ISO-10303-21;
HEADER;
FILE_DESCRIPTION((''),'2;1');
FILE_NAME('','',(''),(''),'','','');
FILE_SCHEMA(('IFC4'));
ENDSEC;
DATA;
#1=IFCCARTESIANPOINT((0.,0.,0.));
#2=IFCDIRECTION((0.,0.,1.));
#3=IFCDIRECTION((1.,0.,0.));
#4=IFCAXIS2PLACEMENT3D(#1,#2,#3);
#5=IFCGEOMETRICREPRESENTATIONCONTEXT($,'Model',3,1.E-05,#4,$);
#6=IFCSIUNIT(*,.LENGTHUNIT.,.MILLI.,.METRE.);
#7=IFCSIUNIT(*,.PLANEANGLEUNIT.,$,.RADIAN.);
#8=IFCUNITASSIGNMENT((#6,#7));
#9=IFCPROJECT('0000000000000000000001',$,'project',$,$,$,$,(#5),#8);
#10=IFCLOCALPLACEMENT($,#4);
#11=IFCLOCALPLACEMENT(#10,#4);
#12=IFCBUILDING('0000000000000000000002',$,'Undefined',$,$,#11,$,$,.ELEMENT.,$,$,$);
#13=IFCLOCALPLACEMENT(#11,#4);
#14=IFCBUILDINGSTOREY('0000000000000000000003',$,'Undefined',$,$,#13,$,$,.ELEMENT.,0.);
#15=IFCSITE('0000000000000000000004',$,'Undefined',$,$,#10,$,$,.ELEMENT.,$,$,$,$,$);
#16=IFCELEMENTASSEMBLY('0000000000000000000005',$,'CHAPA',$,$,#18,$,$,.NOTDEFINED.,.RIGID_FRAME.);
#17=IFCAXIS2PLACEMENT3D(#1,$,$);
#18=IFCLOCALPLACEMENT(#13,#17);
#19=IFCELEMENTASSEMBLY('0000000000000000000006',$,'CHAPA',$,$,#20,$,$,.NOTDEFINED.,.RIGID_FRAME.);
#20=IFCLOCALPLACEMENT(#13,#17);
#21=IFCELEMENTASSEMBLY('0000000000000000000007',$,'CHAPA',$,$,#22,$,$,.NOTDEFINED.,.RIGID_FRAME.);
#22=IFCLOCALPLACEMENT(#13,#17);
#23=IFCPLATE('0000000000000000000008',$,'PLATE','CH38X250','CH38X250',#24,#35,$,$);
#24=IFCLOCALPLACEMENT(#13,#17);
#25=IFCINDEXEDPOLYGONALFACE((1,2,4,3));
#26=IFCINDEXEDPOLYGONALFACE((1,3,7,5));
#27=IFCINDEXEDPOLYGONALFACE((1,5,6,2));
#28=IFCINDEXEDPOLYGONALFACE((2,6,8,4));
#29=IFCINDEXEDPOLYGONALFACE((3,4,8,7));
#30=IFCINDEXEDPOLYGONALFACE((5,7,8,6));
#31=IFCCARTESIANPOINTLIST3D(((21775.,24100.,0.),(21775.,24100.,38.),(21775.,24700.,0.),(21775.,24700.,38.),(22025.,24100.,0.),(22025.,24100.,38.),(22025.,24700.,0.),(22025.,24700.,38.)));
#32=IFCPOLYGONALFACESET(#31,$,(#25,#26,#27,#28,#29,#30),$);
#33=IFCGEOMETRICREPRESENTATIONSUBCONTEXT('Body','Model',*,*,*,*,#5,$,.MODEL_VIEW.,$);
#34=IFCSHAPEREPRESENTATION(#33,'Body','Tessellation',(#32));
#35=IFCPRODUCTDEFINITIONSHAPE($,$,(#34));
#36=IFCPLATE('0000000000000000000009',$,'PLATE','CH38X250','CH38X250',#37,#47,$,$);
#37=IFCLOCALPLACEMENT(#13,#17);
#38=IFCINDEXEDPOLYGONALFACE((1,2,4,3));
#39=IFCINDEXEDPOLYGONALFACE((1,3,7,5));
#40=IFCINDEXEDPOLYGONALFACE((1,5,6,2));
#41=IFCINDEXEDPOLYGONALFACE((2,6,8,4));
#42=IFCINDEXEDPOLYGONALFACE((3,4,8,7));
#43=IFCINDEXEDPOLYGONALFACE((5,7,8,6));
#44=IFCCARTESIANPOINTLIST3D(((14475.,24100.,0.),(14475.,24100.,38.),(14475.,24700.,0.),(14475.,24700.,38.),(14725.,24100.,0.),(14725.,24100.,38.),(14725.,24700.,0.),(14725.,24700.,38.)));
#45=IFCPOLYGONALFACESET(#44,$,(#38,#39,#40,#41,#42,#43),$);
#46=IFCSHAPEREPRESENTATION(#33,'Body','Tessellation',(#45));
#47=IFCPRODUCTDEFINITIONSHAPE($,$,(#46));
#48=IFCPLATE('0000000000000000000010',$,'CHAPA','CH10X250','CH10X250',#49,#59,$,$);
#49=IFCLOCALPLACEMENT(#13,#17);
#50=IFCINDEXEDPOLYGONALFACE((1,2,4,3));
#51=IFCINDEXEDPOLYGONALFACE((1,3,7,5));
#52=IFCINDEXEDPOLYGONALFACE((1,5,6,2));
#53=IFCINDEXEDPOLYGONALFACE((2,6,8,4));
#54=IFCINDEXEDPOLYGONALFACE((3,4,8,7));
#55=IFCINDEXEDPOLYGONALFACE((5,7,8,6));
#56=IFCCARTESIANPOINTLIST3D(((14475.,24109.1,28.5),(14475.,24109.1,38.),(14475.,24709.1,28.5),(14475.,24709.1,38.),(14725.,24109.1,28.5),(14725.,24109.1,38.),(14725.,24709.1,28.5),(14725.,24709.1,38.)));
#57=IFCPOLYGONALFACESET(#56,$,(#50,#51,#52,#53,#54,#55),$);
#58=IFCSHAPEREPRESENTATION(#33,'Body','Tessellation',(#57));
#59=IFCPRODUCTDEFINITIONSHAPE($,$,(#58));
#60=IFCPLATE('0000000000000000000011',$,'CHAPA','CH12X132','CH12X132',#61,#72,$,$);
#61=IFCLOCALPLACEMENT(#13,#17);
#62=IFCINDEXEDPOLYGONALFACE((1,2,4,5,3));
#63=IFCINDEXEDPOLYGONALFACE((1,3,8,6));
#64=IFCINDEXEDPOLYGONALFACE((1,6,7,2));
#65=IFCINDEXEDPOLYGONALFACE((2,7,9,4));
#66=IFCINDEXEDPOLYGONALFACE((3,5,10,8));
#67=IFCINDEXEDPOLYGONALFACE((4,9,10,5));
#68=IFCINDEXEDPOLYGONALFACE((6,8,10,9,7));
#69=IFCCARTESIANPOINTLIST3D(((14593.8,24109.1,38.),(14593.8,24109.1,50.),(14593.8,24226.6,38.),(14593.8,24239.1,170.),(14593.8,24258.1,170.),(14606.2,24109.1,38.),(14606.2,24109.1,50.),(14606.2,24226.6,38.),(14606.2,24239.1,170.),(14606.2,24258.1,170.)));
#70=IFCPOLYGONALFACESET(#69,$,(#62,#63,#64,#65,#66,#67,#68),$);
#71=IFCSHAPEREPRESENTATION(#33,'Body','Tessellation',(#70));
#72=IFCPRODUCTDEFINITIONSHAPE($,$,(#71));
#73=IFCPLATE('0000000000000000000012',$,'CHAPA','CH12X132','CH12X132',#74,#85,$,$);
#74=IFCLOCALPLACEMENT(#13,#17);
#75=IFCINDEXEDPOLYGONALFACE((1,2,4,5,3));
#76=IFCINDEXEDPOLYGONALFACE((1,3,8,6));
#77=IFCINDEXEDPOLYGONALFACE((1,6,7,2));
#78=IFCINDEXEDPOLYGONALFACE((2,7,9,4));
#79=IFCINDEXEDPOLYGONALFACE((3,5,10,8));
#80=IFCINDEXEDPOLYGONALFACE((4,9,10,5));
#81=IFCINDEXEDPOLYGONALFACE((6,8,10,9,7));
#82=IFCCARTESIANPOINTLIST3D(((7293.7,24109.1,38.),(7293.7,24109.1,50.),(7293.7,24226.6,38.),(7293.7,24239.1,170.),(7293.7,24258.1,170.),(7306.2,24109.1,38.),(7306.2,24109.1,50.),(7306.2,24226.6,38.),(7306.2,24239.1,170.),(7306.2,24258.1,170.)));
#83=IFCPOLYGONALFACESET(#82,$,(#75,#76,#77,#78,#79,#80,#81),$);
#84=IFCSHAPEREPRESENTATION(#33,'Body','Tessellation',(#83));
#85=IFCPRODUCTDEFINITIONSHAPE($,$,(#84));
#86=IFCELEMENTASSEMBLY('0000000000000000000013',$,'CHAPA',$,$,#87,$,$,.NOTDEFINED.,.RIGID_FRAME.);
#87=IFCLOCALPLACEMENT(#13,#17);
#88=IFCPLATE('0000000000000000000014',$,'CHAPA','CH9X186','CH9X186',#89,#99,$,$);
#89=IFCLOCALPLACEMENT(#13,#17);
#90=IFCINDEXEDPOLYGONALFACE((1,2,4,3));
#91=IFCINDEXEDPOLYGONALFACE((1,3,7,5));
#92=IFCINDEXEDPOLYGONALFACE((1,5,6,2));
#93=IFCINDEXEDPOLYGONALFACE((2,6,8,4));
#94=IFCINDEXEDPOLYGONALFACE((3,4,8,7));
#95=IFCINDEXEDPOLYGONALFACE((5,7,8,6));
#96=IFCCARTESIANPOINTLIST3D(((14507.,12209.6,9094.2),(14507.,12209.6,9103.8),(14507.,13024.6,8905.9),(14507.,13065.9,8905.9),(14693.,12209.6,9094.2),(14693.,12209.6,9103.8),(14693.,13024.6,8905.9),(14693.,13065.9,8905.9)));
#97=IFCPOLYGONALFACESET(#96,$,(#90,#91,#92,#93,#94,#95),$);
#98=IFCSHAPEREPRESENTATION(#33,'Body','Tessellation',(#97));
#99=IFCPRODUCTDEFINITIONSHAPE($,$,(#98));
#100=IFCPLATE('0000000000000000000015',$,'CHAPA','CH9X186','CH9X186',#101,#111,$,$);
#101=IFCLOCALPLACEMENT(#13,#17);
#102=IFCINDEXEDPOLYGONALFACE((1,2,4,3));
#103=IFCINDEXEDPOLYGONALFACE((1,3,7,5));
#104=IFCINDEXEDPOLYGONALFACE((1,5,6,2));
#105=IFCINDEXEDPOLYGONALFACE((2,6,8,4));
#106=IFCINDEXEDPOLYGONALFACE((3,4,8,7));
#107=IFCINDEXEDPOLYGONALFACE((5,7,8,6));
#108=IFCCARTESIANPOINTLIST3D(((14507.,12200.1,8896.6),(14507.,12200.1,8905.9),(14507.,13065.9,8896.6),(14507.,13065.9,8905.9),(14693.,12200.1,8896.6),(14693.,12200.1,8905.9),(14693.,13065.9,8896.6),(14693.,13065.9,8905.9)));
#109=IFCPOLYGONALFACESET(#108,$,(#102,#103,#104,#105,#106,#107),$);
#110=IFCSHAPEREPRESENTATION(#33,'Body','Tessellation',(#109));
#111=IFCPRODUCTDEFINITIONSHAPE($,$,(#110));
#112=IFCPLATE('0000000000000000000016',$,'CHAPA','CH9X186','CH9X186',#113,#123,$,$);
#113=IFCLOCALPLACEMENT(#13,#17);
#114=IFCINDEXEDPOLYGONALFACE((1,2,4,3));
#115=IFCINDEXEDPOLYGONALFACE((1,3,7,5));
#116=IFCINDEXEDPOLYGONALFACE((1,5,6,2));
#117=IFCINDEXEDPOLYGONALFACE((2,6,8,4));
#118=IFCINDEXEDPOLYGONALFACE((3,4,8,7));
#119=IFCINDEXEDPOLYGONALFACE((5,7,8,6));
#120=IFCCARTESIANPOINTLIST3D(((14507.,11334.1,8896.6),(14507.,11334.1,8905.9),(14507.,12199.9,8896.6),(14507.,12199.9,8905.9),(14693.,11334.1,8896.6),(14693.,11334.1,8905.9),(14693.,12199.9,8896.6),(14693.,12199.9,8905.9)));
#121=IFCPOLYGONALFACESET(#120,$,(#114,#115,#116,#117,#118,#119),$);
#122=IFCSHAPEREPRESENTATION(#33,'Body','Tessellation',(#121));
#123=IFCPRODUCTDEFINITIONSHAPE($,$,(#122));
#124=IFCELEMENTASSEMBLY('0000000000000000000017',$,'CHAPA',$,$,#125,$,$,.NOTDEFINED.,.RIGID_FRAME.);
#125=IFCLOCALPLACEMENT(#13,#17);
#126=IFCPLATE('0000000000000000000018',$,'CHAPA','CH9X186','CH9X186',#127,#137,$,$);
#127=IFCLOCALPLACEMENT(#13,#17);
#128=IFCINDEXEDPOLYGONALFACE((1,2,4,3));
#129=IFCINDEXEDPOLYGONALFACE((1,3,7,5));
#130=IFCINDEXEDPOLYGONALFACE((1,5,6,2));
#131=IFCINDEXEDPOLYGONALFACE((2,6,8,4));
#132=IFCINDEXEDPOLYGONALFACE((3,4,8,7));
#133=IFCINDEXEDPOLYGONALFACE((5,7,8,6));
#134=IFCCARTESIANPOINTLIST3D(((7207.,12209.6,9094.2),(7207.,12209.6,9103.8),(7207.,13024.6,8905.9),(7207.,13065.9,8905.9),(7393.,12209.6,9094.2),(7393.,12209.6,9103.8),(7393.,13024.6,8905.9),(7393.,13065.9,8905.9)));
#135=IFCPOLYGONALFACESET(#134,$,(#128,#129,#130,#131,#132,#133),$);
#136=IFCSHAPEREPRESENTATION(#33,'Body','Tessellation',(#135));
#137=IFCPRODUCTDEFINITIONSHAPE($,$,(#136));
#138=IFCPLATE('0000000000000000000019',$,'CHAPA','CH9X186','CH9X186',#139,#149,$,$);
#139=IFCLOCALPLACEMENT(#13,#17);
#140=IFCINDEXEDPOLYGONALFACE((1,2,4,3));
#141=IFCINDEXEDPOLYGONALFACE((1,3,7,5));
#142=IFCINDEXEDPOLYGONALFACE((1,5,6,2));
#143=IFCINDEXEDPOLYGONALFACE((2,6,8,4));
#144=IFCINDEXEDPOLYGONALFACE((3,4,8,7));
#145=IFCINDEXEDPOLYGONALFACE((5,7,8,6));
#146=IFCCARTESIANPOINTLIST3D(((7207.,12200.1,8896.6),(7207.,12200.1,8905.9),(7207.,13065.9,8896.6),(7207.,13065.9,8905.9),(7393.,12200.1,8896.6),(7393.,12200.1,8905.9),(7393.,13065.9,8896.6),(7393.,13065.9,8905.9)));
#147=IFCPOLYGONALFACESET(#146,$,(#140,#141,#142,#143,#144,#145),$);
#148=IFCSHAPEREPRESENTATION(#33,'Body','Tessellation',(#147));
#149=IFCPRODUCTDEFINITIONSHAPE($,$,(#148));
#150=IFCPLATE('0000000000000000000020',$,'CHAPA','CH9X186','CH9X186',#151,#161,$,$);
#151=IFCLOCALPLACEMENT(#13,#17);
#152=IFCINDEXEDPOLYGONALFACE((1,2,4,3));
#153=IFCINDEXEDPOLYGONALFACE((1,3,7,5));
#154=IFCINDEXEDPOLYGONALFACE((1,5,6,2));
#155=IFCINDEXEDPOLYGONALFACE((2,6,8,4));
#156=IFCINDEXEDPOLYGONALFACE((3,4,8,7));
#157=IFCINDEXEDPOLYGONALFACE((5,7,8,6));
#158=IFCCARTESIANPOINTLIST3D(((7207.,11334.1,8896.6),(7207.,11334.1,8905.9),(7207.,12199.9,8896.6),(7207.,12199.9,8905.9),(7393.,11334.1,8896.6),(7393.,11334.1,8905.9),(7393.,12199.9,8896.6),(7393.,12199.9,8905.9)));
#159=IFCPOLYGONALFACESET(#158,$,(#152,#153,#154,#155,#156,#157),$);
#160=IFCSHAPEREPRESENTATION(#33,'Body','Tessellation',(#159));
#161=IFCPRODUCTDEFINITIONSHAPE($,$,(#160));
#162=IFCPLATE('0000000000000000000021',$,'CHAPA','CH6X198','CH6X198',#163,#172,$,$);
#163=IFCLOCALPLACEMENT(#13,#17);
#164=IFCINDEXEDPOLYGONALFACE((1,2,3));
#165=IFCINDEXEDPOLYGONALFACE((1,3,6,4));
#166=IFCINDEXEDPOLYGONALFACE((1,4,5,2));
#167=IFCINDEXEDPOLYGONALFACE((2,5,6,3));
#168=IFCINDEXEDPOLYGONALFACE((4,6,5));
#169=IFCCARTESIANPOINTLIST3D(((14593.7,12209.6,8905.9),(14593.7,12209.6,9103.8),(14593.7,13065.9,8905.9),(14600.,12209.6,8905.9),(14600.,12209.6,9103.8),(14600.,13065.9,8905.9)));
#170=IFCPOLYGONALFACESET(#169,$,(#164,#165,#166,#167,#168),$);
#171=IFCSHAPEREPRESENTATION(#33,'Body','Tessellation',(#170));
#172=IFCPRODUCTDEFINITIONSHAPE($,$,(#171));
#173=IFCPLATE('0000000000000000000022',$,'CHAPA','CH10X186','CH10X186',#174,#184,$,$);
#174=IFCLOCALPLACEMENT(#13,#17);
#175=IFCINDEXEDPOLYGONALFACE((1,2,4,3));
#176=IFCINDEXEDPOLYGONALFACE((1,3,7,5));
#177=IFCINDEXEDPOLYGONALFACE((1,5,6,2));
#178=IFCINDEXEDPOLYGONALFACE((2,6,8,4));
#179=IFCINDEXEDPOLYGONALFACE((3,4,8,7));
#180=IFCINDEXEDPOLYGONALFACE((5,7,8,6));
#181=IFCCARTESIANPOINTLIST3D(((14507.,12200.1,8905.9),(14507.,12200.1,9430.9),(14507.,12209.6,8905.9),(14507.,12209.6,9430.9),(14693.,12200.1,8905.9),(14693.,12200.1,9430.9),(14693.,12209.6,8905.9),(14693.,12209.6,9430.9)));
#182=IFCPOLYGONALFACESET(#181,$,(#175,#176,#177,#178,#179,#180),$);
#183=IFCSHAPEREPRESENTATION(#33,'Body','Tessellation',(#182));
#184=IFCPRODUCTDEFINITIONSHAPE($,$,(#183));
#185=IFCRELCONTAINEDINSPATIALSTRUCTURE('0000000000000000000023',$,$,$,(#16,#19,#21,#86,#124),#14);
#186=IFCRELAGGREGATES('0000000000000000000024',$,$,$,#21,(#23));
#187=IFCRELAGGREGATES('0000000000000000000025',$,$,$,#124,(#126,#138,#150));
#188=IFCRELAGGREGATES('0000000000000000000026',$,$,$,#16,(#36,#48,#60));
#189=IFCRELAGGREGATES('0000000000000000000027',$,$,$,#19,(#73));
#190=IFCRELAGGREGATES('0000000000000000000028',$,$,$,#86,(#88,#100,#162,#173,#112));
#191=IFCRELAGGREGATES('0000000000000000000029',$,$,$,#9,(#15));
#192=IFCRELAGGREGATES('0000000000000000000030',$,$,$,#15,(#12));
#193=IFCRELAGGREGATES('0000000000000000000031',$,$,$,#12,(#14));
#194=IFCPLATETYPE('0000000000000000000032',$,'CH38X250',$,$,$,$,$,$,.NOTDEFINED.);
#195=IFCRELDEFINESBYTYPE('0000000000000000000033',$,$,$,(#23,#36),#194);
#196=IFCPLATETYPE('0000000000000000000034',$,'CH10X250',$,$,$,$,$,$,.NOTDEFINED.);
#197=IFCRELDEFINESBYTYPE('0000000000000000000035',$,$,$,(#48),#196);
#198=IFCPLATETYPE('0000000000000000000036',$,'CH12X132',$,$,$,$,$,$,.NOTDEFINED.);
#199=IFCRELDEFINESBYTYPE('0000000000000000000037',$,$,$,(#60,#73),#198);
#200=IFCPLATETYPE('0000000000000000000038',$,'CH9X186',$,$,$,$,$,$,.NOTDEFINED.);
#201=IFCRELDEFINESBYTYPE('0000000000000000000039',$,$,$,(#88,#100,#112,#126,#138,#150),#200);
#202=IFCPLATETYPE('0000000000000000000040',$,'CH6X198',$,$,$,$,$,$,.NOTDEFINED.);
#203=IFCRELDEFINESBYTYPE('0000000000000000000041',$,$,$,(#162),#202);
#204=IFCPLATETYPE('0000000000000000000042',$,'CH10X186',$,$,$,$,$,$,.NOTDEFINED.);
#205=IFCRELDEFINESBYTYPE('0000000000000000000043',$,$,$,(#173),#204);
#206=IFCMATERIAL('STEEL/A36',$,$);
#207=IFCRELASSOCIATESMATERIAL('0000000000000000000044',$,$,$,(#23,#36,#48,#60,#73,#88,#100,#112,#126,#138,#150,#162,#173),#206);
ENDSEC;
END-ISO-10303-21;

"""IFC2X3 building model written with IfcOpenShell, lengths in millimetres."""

from ifc_helpers import new_model, si_unit, frame, origin_with_axes, place, context, subcontext, project, spatial, polyline, outline, extrude, clip, halfspace, material, type_object, element, aggregate, save


model = new_model("IFC2X3")

# Units and contexts
model_context = context("Model", 3, precision=1e-05, world=origin_with_axes())
body_context = subcontext(model_context, "Body", "Model", "MODEL_VIEW")
ifc_project = project(units=[si_unit("LENGTHUNIT", "METRE", prefix="MILLI"), si_unit("PLANEANGLEUNIT", "RADIAN")], contexts=[model_context])

# Site, building, storey
site_placement = place(None, origin_with_axes())
site = spatial("IfcSite", under=ifc_project, at=site_placement, Name="Undefined", CompositionType="ELEMENT")
building_placement = place(site_placement, origin_with_axes())
building = spatial("IfcBuilding", under=site, at=building_placement, Name="Undefined", CompositionType="ELEMENT")
storey_placement = place(building_placement, origin_with_axes())
storey = spatial("IfcBuildingStorey", under=building, at=storey_placement, Name="Undefined", CompositionType="ELEMENT", Elevation=0.0)

# Element assemblies
assembly_1_placement = place(storey_placement, origin_with_axes())
assembly_1 = element("IfcElementAssembly", 1, at=assembly_1_placement, inside=storey, Name="CHAPA", AssemblyPlace="NOTDEFINED", PredefinedType="RIGID_FRAME")
assembly_2_placement = place(storey_placement, origin_with_axes())
assembly_2 = element("IfcElementAssembly", 2, at=assembly_2_placement, inside=storey, Name="CHAPA", AssemblyPlace="NOTDEFINED", PredefinedType="RIGID_FRAME")

# Element assembly, plate
assembly_3_placement = place(storey_placement, origin_with_axes())
assembly_3 = element("IfcElementAssembly", 3, at=assembly_3_placement, inside=storey, Name="CHAPA", AssemblyPlace="NOTDEFINED", PredefinedType="RIGID_FRAME")
ifc_material_1 = material(Name="STEEL/A36")
plate_type_1 = type_object("IfcPlateType", Name="CH38X250", PredefinedType="NOTDEFINED")
plate_1_placement = place(assembly_3_placement, frame((21775.0, 24700.0, 19.0), z_axis=(0.0, 0.0, 1.0), x_axis=(0.0, -1.0, 0.0)))
plate_1 = element("IfcPlate", 4, at=plate_1_placement, type_object=plate_type_1, material=ifc_material_1, Name="PLATE", Description="CH38X250", ObjectType="CH38X250", context=body_context, shape_type="SweptSolid", body=[
    extrude(outline(polyline([(0.0, 0.0), (600.0, 0.0), (600.0, 250.0), (0.0, 250.0), (0.0, 0.0)])), frame((0.0, 0.0, -19.0), z_axis=(0.0, 0.0, 1.0), x_axis=(1.0, 0.0, 0.0)), (0.0, 0.0, 1.0), 38.0),
])
aggregate(assembly_3, [plate_1])

# Plates
plate_2_placement = place(assembly_1_placement, frame((14475.0, 24700.0, 19.0), z_axis=(0.0, 0.0, 1.0), x_axis=(0.0, -1.0, 0.0)))
plate_2 = element("IfcPlate", 5, at=plate_2_placement, type_object=plate_type_1, material=ifc_material_1, Name="PLATE", Description="CH38X250", ObjectType="CH38X250", context=body_context, shape_type="SweptSolid", body=[
    extrude(outline(polyline([(0.0, 0.0), (600.0, 0.0), (600.0, 250.0), (0.0, 250.0), (0.0, 0.0)])), frame((0.0, 0.0, -19.0), z_axis=(0.0, 0.0, 1.0), x_axis=(1.0, 0.0, 0.0)), (0.0, 0.0, 1.0), 38.0),
])
plate_type_2 = type_object("IfcPlateType", Name="CH10X250", PredefinedType="NOTDEFINED")
plate_3_placement = place(assembly_1_placement, frame((14475.0, 24709.1, 33.2), z_axis=(0.0, 0.0, -1.0), x_axis=(1.0, 0.0, 0.0)))
plate_3 = element("IfcPlate", 6, at=plate_3_placement, type_object=plate_type_2, material=ifc_material_1, Name="CHAPA", Description="CH10X250", ObjectType="CH10X250", context=body_context, shape_type="SweptSolid", body=[
    extrude(outline(polyline([(0.0, 0.0), (250.0, 0.0), (250.0, 600.0), (0.0, 600.0), (0.0, 0.0)])), frame((0.0, 0.0, -4.8), z_axis=(0.0, 0.0, 1.0), x_axis=(1.0, 0.0, 0.0)), (0.0, 0.0, 1.0), 9.5),
])
plate_type_3 = type_object("IfcPlateType", Name="CH12X132", PredefinedType="NOTDEFINED")
plate_4_placement = place(assembly_1_placement, frame((14600.0, 24226.6, 38.0), z_axis=(-1.0, 0.0, 0.0), x_axis=(0.0, -1.0, 0.0)))
plate_4 = element("IfcPlate", 7, at=plate_4_placement, type_object=plate_type_3, material=ifc_material_1, Name="CHAPA", Description="CH12X132", ObjectType="CH12X132", context=body_context, shape_type="SweptSolid", body=[
    extrude(outline(polyline([(0.0, 0.0), (117.5, 0.0), (117.5, 12.0), (-12.5, 132.0), (-31.6, 132.0), (0.0, 0.0)])), frame((0.0, 0.0, -6.2), z_axis=(0.0, 0.0, 1.0), x_axis=(1.0, 0.0, 0.0)), (0.0, 0.0, 1.0), 12.5),
])
plate_5_placement = place(assembly_2_placement, frame((7300.0, 24226.6, 38.0), z_axis=(-1.0, 0.0, 0.0), x_axis=(0.0, -1.0, 0.0)))
plate_5 = element("IfcPlate", 8, at=plate_5_placement, type_object=plate_type_3, material=ifc_material_1, Name="CHAPA", Description="CH12X132", ObjectType="CH12X132", context=body_context, shape_type="SweptSolid", body=[
    extrude(outline(polyline([(0.0, 0.0), (117.5, 0.0), (117.5, 12.0), (-12.5, 132.0), (-31.6, 132.0), (0.0, 0.0)])), frame((0.0, 0.0, -6.2), z_axis=(0.0, 0.0, 1.0), x_axis=(1.0, 0.0, 0.0)), (0.0, 0.0, 1.0), 12.5),
])

# Element assemblies, plates
assembly_4_placement = place(storey_placement, origin_with_axes())
assembly_4 = element("IfcElementAssembly", 9, at=assembly_4_placement, inside=storey, Name="CHAPA", AssemblyPlace="NOTDEFINED", PredefinedType="RIGID_FRAME")
plate_type_4 = type_object("IfcPlateType", Name="CH9X186", PredefinedType="NOTDEFINED")
plate_6_placement = place(assembly_4_placement, frame((14693.0, 12208.6, 9099.3), z_axis=(0.0, -0.225125, -0.97433), x_axis=(-1.0, 0.0, 0.0)))
plate_6 = element("IfcPlate", 10, at=plate_6_placement, type_object=plate_type_4, material=ifc_material_1, Name="CHAPA", Description="CH9X186", ObjectType="CH9X186", context=body_context, shape_type="Clipping", body=[
    clip(clip(extrude(outline(polyline([(0.0, 0.0), (186.0, 0.0), (186.0, 878.9), (0.0, 878.9), (0.0, 0.0)])), frame((0.0, 0.0, -4.7), z_axis=(0.0, 0.0, 1.0), x_axis=(1.0, 0.0, 0.0)), (0.0, 0.0, 1.0), 9.3), halfspace(frame((186.0, -500.0, 314.0), z_axis=(0.0, 0.225128, 0.974329), x_axis=(-1.0, 0.0, 0.0)), False)), halfspace(frame((0.0, 2.1, 4.7), z_axis=(0.0, -0.97433, 0.225125), x_axis=(1.0, 0.0, 0.0)), False)),
])
plate_7_placement = place(assembly_4_placement, frame((14693.0, 12200.1, 8901.3), z_axis=(0.0, 0.0, -1.0), x_axis=(-1.0, 0.0, 0.0)))
plate_7 = element("IfcPlate", 11, at=plate_7_placement, type_object=plate_type_4, material=ifc_material_1, Name="CHAPA", Description="CH9X186", ObjectType="CH9X186", context=body_context, shape_type="SweptSolid", body=[
    extrude(outline(polyline([(0.0, 0.0), (186.0, 0.0), (186.0, 865.8), (0.0, 865.8), (0.0, 0.0)])), frame((0.0, 0.0, -4.7), z_axis=(0.0, 0.0, 1.0), x_axis=(1.0, 0.0, 0.0)), (0.0, 0.0, 1.0), 9.3),
])
plate_8_placement = place(assembly_4_placement, frame((14693.0, 12199.9, 8901.3), z_axis=(0.0, 0.0, 1.0), x_axis=(-1.0, 0.0, 0.0)))
plate_8 = element("IfcPlate", 12, at=plate_8_placement, type_object=plate_type_4, material=ifc_material_1, Name="CHAPA", Description="CH9X186", ObjectType="CH9X186", context=body_context, shape_type="SweptSolid", body=[
    extrude(outline(polyline([(0.0, 0.0), (186.0, 0.0), (186.0, 865.8), (0.0, 865.8), (0.0, 0.0)])), frame((0.0, 0.0, -4.7), z_axis=(0.0, 0.0, 1.0), x_axis=(1.0, 0.0, 0.0)), (0.0, 0.0, 1.0), 9.3),
])
assembly_5_placement = place(storey_placement, origin_with_axes())
assembly_5 = element("IfcElementAssembly", 13, at=assembly_5_placement, inside=storey, Name="CHAPA", AssemblyPlace="NOTDEFINED", PredefinedType="RIGID_FRAME")
plate_9_placement = place(assembly_5_placement, frame((7393.0, 12208.6, 9099.3), z_axis=(0.0, -0.225125, -0.97433), x_axis=(-1.0, 0.0, 0.0)))
plate_9 = element("IfcPlate", 14, at=plate_9_placement, type_object=plate_type_4, material=ifc_material_1, Name="CHAPA", Description="CH9X186", ObjectType="CH9X186", context=body_context, shape_type="Clipping", body=[
    clip(clip(extrude(outline(polyline([(0.0, 0.0), (186.0, 0.0), (186.0, 878.9), (0.0, 878.9), (0.0, 0.0)])), frame((0.0, 0.0, -4.7), z_axis=(0.0, 0.0, 1.0), x_axis=(1.0, 0.0, 0.0)), (0.0, 0.0, 1.0), 9.3), halfspace(frame((186.0, -500.0, 314.0), z_axis=(0.0, 0.225128, 0.974329), x_axis=(-1.0, 0.0, 0.0)), False)), halfspace(frame((0.0, 2.1, 4.7), z_axis=(0.0, -0.97433, 0.225125), x_axis=(1.0, 0.0, 0.0)), False)),
])
plate_10_placement = place(assembly_5_placement, frame((7393.0, 12200.1, 8901.3), z_axis=(0.0, 0.0, -1.0), x_axis=(-1.0, 0.0, 0.0)))
plate_10 = element("IfcPlate", 15, at=plate_10_placement, type_object=plate_type_4, material=ifc_material_1, Name="CHAPA", Description="CH9X186", ObjectType="CH9X186", context=body_context, shape_type="SweptSolid", body=[
    extrude(outline(polyline([(0.0, 0.0), (186.0, 0.0), (186.0, 865.8), (0.0, 865.8), (0.0, 0.0)])), frame((0.0, 0.0, -4.7), z_axis=(0.0, 0.0, 1.0), x_axis=(1.0, 0.0, 0.0)), (0.0, 0.0, 1.0), 9.3),
])
plate_11_placement = place(assembly_5_placement, frame((7393.0, 12199.9, 8901.3), z_axis=(0.0, 0.0, 1.0), x_axis=(-1.0, 0.0, 0.0)))
plate_11 = element("IfcPlate", 16, at=plate_11_placement, type_object=plate_type_4, material=ifc_material_1, Name="CHAPA", Description="CH9X186", ObjectType="CH9X186", context=body_context, shape_type="SweptSolid", body=[
    extrude(outline(polyline([(0.0, 0.0), (186.0, 0.0), (186.0, 865.8), (0.0, 865.8), (0.0, 0.0)])), frame((0.0, 0.0, -4.7), z_axis=(0.0, 0.0, 1.0), x_axis=(1.0, 0.0, 0.0)), (0.0, 0.0, 1.0), 9.3),
])

# Plates
plate_type_5 = type_object("IfcPlateType", Name="CH6X198", PredefinedType="NOTDEFINED")
plate_12_placement = place(assembly_4_placement, frame((14596.9, 13065.9, 8905.9), z_axis=(-1.0, 0.0, 0.0), x_axis=(0.0, -1.0, 0.0)))
plate_12 = element("IfcPlate", 17, at=plate_12_placement, type_object=plate_type_5, material=ifc_material_1, Name="CHAPA", Description="CH6X198", ObjectType="CH6X198", context=body_context, shape_type="SweptSolid", body=[
    extrude(outline(polyline([(0.0, 0.0), (856.3, 0.0), (856.3, 197.9), (0.0, 0.0)])), frame((0.0, 0.0, -3.1), z_axis=(0.0, 0.0, 1.0), x_axis=(1.0, 0.0, 0.0)), (0.0, 0.0, 1.0), 6.3),
])
plate_type_6 = type_object("IfcPlateType", Name="CH10X186", PredefinedType="NOTDEFINED")
plate_13_placement = place(assembly_4_placement, frame((14693.0, 12204.8, 9430.9), z_axis=(0.0, -1.0, 0.0), x_axis=(-1.0, 0.0, 0.0)))
plate_13 = element("IfcPlate", 18, at=plate_13_placement, type_object=plate_type_6, material=ifc_material_1, Name="CHAPA", Description="CH10X186", ObjectType="CH10X186", context=body_context, shape_type="SweptSolid", body=[
    extrude(outline(polyline([(0.0, 0.0), (186.0, 0.0), (186.0, 525.0), (0.0, 525.0), (0.0, 0.0)])), frame((0.0, 0.0, -4.8), z_axis=(0.0, 0.0, 1.0), x_axis=(1.0, 0.0, 0.0)), (0.0, 0.0, 1.0), 9.5),
])
aggregate(assembly_5, [plate_9, plate_10, plate_11])

aggregate(assembly_1, [plate_2, plate_3, plate_4])
aggregate(assembly_2, [plate_5])
aggregate(assembly_4, [plate_6, plate_7, plate_12, plate_13, plate_8])

save(model, "model.ifc")
